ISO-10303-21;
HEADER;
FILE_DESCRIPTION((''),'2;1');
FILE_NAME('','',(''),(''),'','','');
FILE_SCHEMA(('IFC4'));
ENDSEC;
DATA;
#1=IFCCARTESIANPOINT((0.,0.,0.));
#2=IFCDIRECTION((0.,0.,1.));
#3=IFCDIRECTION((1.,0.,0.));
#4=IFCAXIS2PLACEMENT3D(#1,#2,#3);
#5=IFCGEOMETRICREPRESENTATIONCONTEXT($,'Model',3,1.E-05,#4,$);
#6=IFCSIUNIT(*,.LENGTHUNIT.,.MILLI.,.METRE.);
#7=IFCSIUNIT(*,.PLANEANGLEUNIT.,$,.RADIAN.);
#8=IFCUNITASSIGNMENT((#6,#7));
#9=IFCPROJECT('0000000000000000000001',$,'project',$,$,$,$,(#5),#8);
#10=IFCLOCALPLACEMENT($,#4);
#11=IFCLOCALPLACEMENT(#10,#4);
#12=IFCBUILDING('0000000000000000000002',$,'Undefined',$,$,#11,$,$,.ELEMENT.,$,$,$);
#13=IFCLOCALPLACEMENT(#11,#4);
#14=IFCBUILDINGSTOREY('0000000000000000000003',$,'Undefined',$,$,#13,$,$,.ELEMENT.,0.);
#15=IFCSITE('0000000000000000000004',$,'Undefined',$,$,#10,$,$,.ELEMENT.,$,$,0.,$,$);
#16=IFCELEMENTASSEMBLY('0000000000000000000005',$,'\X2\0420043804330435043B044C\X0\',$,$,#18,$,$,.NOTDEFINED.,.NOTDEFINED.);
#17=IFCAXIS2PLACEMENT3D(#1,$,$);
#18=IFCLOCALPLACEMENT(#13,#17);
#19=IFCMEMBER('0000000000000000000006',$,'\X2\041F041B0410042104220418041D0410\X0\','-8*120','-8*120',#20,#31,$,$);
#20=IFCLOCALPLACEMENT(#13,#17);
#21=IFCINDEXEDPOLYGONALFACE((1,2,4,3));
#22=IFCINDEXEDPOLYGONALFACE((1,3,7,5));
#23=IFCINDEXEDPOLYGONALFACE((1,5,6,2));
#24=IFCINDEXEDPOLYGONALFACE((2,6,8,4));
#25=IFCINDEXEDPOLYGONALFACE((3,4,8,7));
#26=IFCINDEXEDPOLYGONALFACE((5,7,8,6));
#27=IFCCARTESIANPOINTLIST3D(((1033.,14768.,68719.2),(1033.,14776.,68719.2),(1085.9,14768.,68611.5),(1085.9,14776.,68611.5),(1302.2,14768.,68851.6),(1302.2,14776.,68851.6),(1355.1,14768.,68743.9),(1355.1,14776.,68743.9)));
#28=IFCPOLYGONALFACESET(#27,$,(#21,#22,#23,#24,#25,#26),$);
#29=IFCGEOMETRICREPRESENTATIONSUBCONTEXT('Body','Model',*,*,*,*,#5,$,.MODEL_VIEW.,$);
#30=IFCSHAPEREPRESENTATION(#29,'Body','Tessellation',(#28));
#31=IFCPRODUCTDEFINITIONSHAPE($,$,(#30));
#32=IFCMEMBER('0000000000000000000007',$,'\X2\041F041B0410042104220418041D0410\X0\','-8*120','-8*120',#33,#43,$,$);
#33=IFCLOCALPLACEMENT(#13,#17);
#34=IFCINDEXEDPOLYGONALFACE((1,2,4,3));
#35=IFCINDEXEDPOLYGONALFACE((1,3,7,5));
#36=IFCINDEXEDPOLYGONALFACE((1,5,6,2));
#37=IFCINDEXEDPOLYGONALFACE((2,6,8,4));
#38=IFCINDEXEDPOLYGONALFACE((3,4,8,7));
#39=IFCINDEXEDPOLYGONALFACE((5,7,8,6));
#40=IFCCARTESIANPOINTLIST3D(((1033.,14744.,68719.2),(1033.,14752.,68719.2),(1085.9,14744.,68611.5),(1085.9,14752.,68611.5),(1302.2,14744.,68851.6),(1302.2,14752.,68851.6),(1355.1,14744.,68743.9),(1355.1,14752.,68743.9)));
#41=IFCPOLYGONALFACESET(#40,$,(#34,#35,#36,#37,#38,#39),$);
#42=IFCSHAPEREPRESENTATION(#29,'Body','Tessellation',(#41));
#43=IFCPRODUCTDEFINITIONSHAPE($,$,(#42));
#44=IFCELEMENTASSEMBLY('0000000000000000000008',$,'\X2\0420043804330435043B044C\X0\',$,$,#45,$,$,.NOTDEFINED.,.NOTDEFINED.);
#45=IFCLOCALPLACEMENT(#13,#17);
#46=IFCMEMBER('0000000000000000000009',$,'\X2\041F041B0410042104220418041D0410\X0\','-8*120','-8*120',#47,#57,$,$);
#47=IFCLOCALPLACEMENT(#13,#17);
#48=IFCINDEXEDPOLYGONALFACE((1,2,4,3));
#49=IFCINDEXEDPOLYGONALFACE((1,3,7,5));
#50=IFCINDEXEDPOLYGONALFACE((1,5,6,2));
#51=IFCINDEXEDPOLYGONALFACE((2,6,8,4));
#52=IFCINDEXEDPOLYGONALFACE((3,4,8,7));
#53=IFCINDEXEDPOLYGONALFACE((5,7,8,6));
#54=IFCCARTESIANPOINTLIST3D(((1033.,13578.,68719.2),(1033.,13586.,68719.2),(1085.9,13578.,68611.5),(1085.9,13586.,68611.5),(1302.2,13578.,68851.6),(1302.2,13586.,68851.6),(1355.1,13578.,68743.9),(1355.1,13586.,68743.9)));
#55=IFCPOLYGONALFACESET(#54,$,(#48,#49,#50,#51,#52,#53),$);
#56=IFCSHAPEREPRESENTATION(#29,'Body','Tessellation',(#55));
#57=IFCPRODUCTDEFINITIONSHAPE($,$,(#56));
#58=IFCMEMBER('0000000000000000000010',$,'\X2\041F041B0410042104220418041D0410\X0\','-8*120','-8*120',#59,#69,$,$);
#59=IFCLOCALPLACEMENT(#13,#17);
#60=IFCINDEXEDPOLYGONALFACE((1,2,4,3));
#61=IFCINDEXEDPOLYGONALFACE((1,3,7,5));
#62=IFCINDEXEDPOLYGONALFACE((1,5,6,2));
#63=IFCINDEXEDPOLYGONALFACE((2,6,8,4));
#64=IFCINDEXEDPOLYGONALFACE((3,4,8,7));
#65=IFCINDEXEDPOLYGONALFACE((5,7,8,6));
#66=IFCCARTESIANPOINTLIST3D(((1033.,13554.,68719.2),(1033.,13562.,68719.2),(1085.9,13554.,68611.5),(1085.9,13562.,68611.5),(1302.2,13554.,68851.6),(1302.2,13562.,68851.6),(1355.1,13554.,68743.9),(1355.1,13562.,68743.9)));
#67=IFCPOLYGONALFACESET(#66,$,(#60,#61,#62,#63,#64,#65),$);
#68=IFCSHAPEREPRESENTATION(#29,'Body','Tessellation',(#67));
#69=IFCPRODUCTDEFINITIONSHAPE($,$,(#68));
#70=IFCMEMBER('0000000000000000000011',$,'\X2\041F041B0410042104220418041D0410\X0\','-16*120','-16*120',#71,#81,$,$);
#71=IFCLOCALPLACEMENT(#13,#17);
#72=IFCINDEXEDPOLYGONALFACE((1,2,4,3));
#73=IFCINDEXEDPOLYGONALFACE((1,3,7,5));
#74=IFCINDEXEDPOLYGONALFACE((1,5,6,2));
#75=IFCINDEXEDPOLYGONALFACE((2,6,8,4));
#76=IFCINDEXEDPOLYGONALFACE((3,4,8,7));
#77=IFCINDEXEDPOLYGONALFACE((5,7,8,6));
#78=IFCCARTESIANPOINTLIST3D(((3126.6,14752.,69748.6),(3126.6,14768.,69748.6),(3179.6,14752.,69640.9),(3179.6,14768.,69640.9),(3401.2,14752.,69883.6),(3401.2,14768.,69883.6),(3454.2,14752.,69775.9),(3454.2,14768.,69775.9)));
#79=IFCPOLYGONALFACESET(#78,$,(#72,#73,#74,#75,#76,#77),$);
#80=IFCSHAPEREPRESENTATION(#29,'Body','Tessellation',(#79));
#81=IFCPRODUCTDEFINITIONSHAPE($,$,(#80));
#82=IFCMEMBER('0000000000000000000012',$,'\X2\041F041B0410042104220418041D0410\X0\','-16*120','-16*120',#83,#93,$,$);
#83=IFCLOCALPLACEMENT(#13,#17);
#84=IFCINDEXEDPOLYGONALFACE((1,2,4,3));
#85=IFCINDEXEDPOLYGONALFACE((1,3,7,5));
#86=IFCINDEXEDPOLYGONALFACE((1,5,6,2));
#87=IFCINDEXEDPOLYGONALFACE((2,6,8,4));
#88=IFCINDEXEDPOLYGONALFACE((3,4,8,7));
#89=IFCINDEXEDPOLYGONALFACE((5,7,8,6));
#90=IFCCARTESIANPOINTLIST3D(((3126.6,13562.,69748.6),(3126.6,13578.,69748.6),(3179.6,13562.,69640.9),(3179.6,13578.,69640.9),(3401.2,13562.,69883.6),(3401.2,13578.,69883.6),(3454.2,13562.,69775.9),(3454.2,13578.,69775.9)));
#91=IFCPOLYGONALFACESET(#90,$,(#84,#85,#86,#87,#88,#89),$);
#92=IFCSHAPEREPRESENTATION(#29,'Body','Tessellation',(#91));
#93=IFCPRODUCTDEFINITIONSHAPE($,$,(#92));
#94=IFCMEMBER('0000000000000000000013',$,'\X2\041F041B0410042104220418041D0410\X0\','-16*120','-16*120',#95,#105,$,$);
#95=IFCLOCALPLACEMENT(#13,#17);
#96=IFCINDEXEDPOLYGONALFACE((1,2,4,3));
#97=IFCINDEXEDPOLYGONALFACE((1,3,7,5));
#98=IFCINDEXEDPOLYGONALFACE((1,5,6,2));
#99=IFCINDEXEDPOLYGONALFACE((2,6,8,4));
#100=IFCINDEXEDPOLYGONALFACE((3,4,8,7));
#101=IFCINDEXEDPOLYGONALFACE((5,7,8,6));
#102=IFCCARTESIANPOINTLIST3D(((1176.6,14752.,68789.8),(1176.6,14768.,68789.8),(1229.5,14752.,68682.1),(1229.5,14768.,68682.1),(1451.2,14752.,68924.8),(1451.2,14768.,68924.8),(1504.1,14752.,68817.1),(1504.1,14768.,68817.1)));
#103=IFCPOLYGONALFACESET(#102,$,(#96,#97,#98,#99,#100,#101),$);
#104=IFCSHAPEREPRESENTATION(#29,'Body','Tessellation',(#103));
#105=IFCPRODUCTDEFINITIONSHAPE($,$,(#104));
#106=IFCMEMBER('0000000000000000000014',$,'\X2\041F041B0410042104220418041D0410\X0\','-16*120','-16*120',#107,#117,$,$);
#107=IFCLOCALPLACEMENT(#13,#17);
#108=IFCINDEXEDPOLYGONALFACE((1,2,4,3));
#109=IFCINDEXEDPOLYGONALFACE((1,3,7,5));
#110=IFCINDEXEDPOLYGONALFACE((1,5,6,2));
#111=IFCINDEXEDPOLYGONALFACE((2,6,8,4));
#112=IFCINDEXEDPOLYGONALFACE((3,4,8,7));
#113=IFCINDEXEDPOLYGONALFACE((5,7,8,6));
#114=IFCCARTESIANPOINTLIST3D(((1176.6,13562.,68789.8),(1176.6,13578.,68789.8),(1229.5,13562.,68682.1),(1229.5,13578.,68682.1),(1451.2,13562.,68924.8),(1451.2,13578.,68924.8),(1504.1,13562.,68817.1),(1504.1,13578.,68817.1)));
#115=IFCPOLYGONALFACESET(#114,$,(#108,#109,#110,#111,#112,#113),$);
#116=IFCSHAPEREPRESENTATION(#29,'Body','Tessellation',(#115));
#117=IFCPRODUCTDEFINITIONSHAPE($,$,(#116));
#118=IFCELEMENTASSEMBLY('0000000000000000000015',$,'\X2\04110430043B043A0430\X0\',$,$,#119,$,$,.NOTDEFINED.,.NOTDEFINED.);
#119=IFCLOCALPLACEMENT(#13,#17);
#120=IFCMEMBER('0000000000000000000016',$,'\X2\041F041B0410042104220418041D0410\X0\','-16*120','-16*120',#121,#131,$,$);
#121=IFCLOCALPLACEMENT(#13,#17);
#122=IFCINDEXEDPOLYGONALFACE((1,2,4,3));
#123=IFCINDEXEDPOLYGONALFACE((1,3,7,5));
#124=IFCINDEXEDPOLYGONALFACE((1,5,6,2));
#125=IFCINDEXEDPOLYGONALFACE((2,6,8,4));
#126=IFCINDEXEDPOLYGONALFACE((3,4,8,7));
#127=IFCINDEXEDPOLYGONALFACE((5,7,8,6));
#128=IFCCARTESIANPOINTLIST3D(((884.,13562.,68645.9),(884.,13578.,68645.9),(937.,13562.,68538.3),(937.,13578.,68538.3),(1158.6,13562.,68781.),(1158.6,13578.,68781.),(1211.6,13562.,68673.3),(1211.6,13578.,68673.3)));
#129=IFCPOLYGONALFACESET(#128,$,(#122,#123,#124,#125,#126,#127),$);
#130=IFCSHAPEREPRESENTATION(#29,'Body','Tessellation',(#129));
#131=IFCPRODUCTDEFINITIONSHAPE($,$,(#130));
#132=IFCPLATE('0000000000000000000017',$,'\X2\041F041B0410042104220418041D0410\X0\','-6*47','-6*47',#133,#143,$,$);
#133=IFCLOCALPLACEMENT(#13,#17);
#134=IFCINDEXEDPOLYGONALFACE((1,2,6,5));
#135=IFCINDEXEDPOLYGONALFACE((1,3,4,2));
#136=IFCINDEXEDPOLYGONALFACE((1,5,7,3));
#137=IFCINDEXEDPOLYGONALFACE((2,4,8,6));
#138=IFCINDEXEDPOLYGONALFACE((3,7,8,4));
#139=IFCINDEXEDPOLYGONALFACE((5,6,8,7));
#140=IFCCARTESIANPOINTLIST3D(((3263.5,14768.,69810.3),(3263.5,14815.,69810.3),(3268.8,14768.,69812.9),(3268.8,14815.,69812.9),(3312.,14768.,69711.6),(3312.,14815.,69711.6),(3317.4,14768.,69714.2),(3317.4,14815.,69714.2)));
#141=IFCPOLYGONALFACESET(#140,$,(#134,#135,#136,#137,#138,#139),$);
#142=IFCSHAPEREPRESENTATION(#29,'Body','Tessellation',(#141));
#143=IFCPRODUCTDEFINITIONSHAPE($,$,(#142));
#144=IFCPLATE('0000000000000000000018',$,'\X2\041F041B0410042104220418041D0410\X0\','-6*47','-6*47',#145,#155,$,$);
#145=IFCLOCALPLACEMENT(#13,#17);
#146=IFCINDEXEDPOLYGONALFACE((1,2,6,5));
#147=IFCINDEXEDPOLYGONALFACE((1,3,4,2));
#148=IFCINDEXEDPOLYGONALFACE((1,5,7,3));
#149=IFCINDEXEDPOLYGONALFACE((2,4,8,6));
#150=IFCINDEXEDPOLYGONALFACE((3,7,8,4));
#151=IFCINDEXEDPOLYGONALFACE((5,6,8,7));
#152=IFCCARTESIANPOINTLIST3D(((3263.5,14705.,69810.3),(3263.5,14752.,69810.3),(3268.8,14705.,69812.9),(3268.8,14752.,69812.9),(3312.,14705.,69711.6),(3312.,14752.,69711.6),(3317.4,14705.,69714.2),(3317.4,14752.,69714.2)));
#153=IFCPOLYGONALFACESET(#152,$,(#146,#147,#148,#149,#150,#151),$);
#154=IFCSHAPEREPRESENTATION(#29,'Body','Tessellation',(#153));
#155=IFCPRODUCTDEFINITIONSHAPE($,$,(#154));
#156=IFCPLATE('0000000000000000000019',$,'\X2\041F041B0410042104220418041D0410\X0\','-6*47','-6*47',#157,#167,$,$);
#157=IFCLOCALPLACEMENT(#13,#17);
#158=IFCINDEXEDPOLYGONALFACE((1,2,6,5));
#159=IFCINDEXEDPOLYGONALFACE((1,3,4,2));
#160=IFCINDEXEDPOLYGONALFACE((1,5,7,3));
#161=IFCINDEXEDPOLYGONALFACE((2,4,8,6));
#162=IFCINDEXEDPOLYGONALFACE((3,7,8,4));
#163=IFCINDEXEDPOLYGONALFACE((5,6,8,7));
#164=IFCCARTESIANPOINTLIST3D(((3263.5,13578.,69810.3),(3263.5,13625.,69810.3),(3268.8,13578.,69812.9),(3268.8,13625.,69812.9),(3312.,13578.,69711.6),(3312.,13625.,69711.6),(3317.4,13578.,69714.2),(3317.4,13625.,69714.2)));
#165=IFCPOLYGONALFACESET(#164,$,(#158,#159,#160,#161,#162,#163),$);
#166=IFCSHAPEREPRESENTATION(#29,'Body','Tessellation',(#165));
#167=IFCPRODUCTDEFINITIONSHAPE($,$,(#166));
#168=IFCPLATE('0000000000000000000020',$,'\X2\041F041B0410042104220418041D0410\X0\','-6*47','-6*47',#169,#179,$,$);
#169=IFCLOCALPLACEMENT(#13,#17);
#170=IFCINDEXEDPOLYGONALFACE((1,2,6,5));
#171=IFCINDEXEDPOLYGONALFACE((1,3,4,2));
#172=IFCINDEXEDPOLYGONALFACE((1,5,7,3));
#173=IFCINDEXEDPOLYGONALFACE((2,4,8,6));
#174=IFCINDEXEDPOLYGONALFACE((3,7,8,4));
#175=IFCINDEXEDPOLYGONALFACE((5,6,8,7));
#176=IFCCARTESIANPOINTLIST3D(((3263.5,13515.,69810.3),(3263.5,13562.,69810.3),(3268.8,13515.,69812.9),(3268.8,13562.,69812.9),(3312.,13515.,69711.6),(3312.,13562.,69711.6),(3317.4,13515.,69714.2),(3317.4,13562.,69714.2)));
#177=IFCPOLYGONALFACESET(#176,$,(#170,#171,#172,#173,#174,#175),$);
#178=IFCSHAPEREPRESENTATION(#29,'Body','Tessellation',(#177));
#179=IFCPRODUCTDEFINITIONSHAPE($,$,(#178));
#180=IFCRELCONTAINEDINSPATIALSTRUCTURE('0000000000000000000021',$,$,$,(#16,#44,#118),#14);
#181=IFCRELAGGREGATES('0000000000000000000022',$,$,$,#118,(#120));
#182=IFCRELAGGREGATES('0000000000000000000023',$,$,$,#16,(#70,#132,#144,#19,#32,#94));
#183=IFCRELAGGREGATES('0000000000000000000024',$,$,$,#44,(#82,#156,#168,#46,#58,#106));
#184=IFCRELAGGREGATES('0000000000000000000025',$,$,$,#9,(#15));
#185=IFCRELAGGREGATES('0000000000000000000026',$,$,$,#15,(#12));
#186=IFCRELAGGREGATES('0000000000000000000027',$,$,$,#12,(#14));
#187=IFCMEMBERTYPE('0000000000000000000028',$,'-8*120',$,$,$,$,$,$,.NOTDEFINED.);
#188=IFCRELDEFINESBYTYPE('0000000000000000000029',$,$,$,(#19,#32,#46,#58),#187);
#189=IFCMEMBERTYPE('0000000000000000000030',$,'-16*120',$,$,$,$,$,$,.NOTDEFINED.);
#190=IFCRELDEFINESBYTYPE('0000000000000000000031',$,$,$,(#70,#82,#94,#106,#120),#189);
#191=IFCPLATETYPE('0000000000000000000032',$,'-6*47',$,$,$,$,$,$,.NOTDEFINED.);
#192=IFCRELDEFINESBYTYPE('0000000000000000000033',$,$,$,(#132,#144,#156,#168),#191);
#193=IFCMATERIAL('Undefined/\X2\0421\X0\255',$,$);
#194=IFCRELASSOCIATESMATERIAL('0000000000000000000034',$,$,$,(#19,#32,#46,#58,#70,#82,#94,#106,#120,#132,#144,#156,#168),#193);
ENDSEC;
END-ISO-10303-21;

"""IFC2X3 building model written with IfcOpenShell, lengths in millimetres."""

from ifc_helpers import new_model, si_unit, frame, origin_with_axes, origin_2d_with_axis, place, context, subcontext, project, spatial, polyline, rectangle, outline, extrude, boolean, material, type_object, element, aggregate, save


model = new_model("IFC2X3")

# Units and contexts
model_context = context("Model", 3, precision=1e-05, world=origin_with_axes())
body_context = subcontext(model_context, "Body", "Model", "MODEL_VIEW")
ifc_project = project(units=[si_unit("LENGTHUNIT", "METRE", prefix="MILLI"), si_unit("PLANEANGLEUNIT", "RADIAN")], contexts=[model_context])

# Site, building, storey
site_placement = place(None, origin_with_axes())
site = spatial("IfcSite", under=ifc_project, at=site_placement, Name="Undefined", CompositionType="ELEMENT", RefElevation=0.0)
building_placement = place(site_placement, origin_with_axes())
building = spatial("IfcBuilding", under=site, at=building_placement, Name="Undefined", CompositionType="ELEMENT")
storey_placement = place(building_placement, origin_with_axes())
storey = spatial("IfcBuildingStorey", under=building, at=storey_placement, Name="Undefined", CompositionType="ELEMENT", Elevation=0.0)

# Element assemblies, members
assembly_1_placement = place(storey_placement, origin_with_axes())
assembly_1 = element("IfcElementAssembly", 1, at=assembly_1_placement, inside=storey, Name="Ригель", AssemblyPlace="NOTDEFINED", PredefinedType="NOTDEFINED")
ifc_material_1 = material(Name="Undefined/С255")
member_type_1 = type_object("IfcMemberType", Name="-8*120", PredefinedType="NOTDEFINED")
member_1_placement = place(assembly_1_placement, frame((1059.5, 14772.0, 68665.3), z_axis=(0.441221, 0.0, -0.897399), x_axis=(0.897399, 0.0, 0.441221)))
member_1 = element("IfcMember", 2, at=member_1_placement, type_object=member_type_1, material=ifc_material_1, Name="ПЛАСТИНА", Description="-8*120", ObjectType="-8*120", context=body_context, shape_type="SweptSolid", body=[
    extrude(rectangle(XDim=8.0, YDim=120.0, at=origin_2d_with_axis()), frame((300.0, 0.0, 0.0), z_axis=(-1.0, 0.0, 0.0), x_axis=(0.0, -1.0, 0.0)), (0.0, 0.0, 1.0), 300.0),
])
member_2_placement = place(assembly_1_placement, frame((1059.5, 14748.0, 68665.3), z_axis=(0.441221, 0.0, -0.897399), x_axis=(0.897399, 0.0, 0.441221)))
member_2 = element("IfcMember", 3, at=member_2_placement, type_object=member_type_1, material=ifc_material_1, Name="ПЛАСТИНА", Description="-8*120", ObjectType="-8*120", context=body_context, shape_type="SweptSolid", body=[
    extrude(rectangle(XDim=8.0, YDim=120.0, at=origin_2d_with_axis()), frame((300.0, 0.0, 0.0), z_axis=(-1.0, 0.0, 0.0), x_axis=(0.0, -1.0, 0.0)), (0.0, 0.0, 1.0), 300.0),
])
assembly_2_placement = place(storey_placement, origin_with_axes())
assembly_2 = element("IfcElementAssembly", 4, at=assembly_2_placement, inside=storey, Name="Ригель", AssemblyPlace="NOTDEFINED", PredefinedType="NOTDEFINED")
member_3_placement = place(assembly_2_placement, frame((1059.5, 13582.0, 68665.3), z_axis=(0.441221, 0.0, -0.897399), x_axis=(0.897399, 0.0, 0.441221)))
member_3 = element("IfcMember", 5, at=member_3_placement, type_object=member_type_1, material=ifc_material_1, Name="ПЛАСТИНА", Description="-8*120", ObjectType="-8*120", context=body_context, shape_type="SweptSolid", body=[
    extrude(rectangle(XDim=8.0, YDim=120.0, at=origin_2d_with_axis()), frame((300.0, 0.0, 0.0), z_axis=(-1.0, 0.0, 0.0), x_axis=(0.0, -1.0, 0.0)), (0.0, 0.0, 1.0), 300.0),
])
member_4_placement = place(assembly_2_placement, frame((1059.5, 13558.0, 68665.3), z_axis=(0.441221, 0.0, -0.897399), x_axis=(0.897399, 0.0, 0.441221)))
member_4 = element("IfcMember", 6, at=member_4_placement, type_object=member_type_1, material=ifc_material_1, Name="ПЛАСТИНА", Description="-8*120", ObjectType="-8*120", context=body_context, shape_type="SweptSolid", body=[
    extrude(rectangle(XDim=8.0, YDim=120.0, at=origin_2d_with_axis()), frame((300.0, 0.0, 0.0), z_axis=(-1.0, 0.0, 0.0), x_axis=(0.0, -1.0, 0.0)), (0.0, 0.0, 1.0), 300.0),
])

# Members
member_type_2 = type_object("IfcMemberType", Name="-16*120", PredefinedType="NOTDEFINED")
member_5_placement = place(assembly_1_placement, frame((3153.1, 14760.0, 69694.7), z_axis=(0.441221, 0.0, -0.897399), x_axis=(0.897399, 0.0, 0.441221)))
member_5 = element("IfcMember", 7, at=member_5_placement, type_object=member_type_2, material=ifc_material_1, Name="ПЛАСТИНА", Description="-16*120", ObjectType="-16*120", context=body_context, shape_type="SweptSolid", body=[
    extrude(rectangle(XDim=16.0, YDim=120.0, at=origin_2d_with_axis()), frame((306.0, 0.0, 0.0), z_axis=(-1.0, 0.0, 0.0), x_axis=(0.0, -1.0, 0.0)), (0.0, 0.0, 1.0), 306.0),
])
member_6_placement = place(assembly_2_placement, frame((3153.1, 13570.0, 69694.7), z_axis=(0.441221, 0.0, -0.897399), x_axis=(0.897399, 0.0, 0.441221)))
member_6 = element("IfcMember", 8, at=member_6_placement, type_object=member_type_2, material=ifc_material_1, Name="ПЛАСТИНА", Description="-16*120", ObjectType="-16*120", context=body_context, shape_type="SweptSolid", body=[
    extrude(rectangle(XDim=16.0, YDim=120.0, at=origin_2d_with_axis()), frame((306.0, 0.0, 0.0), z_axis=(-1.0, 0.0, 0.0), x_axis=(0.0, -1.0, 0.0)), (0.0, 0.0, 1.0), 306.0),
])
member_7_placement = place(assembly_1_placement, frame((1203.0, 14760.0, 68735.9), z_axis=(0.441221, 0.0, -0.897399), x_axis=(0.897399, 0.0, 0.441221)))
member_7 = element("IfcMember", 9, at=member_7_placement, type_object=member_type_2, material=ifc_material_1, Name="ПЛАСТИНА", Description="-16*120", ObjectType="-16*120", context=body_context, shape_type="SweptSolid", body=[
    extrude(rectangle(XDim=16.0, YDim=120.0, at=origin_2d_with_axis()), frame((306.0, 0.0, 0.0), z_axis=(-1.0, 0.0, 0.0), x_axis=(0.0, -1.0, 0.0)), (0.0, 0.0, 1.0), 306.0),
])
member_8_placement = place(assembly_2_placement, frame((1203.0, 13570.0, 68735.9), z_axis=(0.441221, 0.0, -0.897399), x_axis=(0.897399, 0.0, 0.441221)))
member_8 = element("IfcMember", 10, at=member_8_placement, type_object=member_type_2, material=ifc_material_1, Name="ПЛАСТИНА", Description="-16*120", ObjectType="-16*120", context=body_context, shape_type="SweptSolid", body=[
    extrude(rectangle(XDim=16.0, YDim=120.0, at=origin_2d_with_axis()), frame((306.0, 0.0, 0.0), z_axis=(-1.0, 0.0, 0.0), x_axis=(0.0, -1.0, 0.0)), (0.0, 0.0, 1.0), 306.0),
])

# Element assembly, member
assembly_3_placement = place(storey_placement, origin_with_axes())
assembly_3 = element("IfcElementAssembly", 11, at=assembly_3_placement, inside=storey, Name="Балка", AssemblyPlace="NOTDEFINED", PredefinedType="NOTDEFINED")
member_9_placement = place(assembly_3_placement, frame((910.5, 13570.0, 68592.1), z_axis=(0.441221, 0.0, -0.897399), x_axis=(0.897399, 0.0, 0.441221)))
member_9 = element("IfcMember", 12, at=member_9_placement, type_object=member_type_2, material=ifc_material_1, Name="ПЛАСТИНА", Description="-16*120", ObjectType="-16*120", context=body_context, shape_type="SweptSolid", body=[
    extrude(rectangle(XDim=16.0, YDim=120.0, at=origin_2d_with_axis()), frame((306.0, 0.0, 0.0), z_axis=(-1.0, 0.0, 0.0), x_axis=(0.0, -1.0, 0.0)), (0.0, 0.0, 1.0), 306.0),
])
aggregate(assembly_3, [member_9])

# Plates
plate_type = type_object("IfcPlateType", Name="-6*47", PredefinedType="NOTDEFINED")
plate_1_placement = place(assembly_1_placement, frame((3266.1, 14705.0, 69811.6), z_axis=(0.897399, 0.0, 0.441221), x_axis=(0.441221, 0.0, -0.897399)))
plate_1 = element("IfcPlate", 13, at=plate_1_placement, type_object=plate_type, material=ifc_material_1, Name="ПЛАСТИНА", Description="-6*47", ObjectType="-6*47", context=body_context, shape_type="CSG", body=[
    boolean("DIFFERENCE", extrude(outline(polyline([(0.0, 0.0), (110.0, 0.0), (110.0, 110.0), (0.0, 110.0), (0.0, 0.0)])), frame((0.0, 0.0, -3.0), z_axis=(0.0, 0.0, 1.0), x_axis=(1.0, 0.0, 0.0)), (0.0, 0.0, 1.0), 6.0), extrude(rectangle(XDim=26.0, YDim=130.0, at=origin_2d_with_axis()), frame((55.0, -3.0, 0.0), z_axis=(0.0, 1.0, 0.0), x_axis=(0.0, 0.0, -1.0)), (0.0, 0.0, 1.0), 66.0)),
])
plate_2_placement = place(assembly_1_placement, frame((3266.1, 14705.0, 69811.6), z_axis=(0.897399, 0.0, 0.441221), x_axis=(0.441221, 0.0, -0.897399)))
plate_2 = element("IfcPlate", 14, at=plate_2_placement, type_object=plate_type, material=ifc_material_1, Name="ПЛАСТИНА", Description="-6*47", ObjectType="-6*47", context=body_context, shape_type="CSG", body=[
    boolean("DIFFERENCE", extrude(outline(polyline([(0.0, 0.0), (110.0, 0.0), (110.0, 110.0), (0.0, 110.0), (0.0, 0.0)])), frame((0.0, 0.0, -3.0), z_axis=(0.0, 0.0, 1.0), x_axis=(1.0, 0.0, 0.0)), (0.0, 0.0, 1.0), 6.0), extrude(rectangle(XDim=26.0, YDim=130.0, at=origin_2d_with_axis()), frame((55.0, 47.0, 0.0), z_axis=(0.0, 1.0, 0.0), x_axis=(0.0, 0.0, -1.0)), (0.0, 0.0, 1.0), 66.0)),
])
plate_3_placement = place(assembly_2_placement, frame((3266.1, 13515.0, 69811.6), z_axis=(0.897399, 0.0, 0.441221), x_axis=(0.441221, 0.0, -0.897399)))
plate_3 = element("IfcPlate", 15, at=plate_3_placement, type_object=plate_type, material=ifc_material_1, Name="ПЛАСТИНА", Description="-6*47", ObjectType="-6*47", context=body_context, shape_type="CSG", body=[
    boolean("DIFFERENCE", extrude(outline(polyline([(0.0, 0.0), (110.0, 0.0), (110.0, 110.0), (0.0, 110.0), (0.0, 0.0)])), frame((0.0, 0.0, -3.0), z_axis=(0.0, 0.0, 1.0), x_axis=(1.0, 0.0, 0.0)), (0.0, 0.0, 1.0), 6.0), extrude(rectangle(XDim=26.0, YDim=130.0, at=origin_2d_with_axis()), frame((55.0, -3.0, 0.0), z_axis=(0.0, 1.0, 0.0), x_axis=(0.0, 0.0, -1.0)), (0.0, 0.0, 1.0), 66.0)),
])
plate_4_placement = place(assembly_2_placement, frame((3266.1, 13515.0, 69811.6), z_axis=(0.897399, 0.0, 0.441221), x_axis=(0.441221, 0.0, -0.897399)))
plate_4 = element("IfcPlate", 16, at=plate_4_placement, type_object=plate_type, material=ifc_material_1, Name="ПЛАСТИНА", Description="-6*47", ObjectType="-6*47", context=body_context, shape_type="CSG", body=[
    boolean("DIFFERENCE", extrude(outline(polyline([(0.0, 0.0), (110.0, 0.0), (110.0, 110.0), (0.0, 110.0), (0.0, 0.0)])), frame((0.0, 0.0, -3.0), z_axis=(0.0, 0.0, 1.0), x_axis=(1.0, 0.0, 0.0)), (0.0, 0.0, 1.0), 6.0), extrude(rectangle(XDim=26.0, YDim=130.0, at=origin_2d_with_axis()), frame((55.0, 47.0, 0.0), z_axis=(0.0, 1.0, 0.0), x_axis=(0.0, 0.0, -1.0)), (0.0, 0.0, 1.0), 66.0)),
])

aggregate(assembly_1, [member_5, plate_1, plate_2, member_1, member_2, member_7])
aggregate(assembly_2, [member_6, plate_3, plate_4, member_3, member_4, member_8])

save(model, "model.ifc")
